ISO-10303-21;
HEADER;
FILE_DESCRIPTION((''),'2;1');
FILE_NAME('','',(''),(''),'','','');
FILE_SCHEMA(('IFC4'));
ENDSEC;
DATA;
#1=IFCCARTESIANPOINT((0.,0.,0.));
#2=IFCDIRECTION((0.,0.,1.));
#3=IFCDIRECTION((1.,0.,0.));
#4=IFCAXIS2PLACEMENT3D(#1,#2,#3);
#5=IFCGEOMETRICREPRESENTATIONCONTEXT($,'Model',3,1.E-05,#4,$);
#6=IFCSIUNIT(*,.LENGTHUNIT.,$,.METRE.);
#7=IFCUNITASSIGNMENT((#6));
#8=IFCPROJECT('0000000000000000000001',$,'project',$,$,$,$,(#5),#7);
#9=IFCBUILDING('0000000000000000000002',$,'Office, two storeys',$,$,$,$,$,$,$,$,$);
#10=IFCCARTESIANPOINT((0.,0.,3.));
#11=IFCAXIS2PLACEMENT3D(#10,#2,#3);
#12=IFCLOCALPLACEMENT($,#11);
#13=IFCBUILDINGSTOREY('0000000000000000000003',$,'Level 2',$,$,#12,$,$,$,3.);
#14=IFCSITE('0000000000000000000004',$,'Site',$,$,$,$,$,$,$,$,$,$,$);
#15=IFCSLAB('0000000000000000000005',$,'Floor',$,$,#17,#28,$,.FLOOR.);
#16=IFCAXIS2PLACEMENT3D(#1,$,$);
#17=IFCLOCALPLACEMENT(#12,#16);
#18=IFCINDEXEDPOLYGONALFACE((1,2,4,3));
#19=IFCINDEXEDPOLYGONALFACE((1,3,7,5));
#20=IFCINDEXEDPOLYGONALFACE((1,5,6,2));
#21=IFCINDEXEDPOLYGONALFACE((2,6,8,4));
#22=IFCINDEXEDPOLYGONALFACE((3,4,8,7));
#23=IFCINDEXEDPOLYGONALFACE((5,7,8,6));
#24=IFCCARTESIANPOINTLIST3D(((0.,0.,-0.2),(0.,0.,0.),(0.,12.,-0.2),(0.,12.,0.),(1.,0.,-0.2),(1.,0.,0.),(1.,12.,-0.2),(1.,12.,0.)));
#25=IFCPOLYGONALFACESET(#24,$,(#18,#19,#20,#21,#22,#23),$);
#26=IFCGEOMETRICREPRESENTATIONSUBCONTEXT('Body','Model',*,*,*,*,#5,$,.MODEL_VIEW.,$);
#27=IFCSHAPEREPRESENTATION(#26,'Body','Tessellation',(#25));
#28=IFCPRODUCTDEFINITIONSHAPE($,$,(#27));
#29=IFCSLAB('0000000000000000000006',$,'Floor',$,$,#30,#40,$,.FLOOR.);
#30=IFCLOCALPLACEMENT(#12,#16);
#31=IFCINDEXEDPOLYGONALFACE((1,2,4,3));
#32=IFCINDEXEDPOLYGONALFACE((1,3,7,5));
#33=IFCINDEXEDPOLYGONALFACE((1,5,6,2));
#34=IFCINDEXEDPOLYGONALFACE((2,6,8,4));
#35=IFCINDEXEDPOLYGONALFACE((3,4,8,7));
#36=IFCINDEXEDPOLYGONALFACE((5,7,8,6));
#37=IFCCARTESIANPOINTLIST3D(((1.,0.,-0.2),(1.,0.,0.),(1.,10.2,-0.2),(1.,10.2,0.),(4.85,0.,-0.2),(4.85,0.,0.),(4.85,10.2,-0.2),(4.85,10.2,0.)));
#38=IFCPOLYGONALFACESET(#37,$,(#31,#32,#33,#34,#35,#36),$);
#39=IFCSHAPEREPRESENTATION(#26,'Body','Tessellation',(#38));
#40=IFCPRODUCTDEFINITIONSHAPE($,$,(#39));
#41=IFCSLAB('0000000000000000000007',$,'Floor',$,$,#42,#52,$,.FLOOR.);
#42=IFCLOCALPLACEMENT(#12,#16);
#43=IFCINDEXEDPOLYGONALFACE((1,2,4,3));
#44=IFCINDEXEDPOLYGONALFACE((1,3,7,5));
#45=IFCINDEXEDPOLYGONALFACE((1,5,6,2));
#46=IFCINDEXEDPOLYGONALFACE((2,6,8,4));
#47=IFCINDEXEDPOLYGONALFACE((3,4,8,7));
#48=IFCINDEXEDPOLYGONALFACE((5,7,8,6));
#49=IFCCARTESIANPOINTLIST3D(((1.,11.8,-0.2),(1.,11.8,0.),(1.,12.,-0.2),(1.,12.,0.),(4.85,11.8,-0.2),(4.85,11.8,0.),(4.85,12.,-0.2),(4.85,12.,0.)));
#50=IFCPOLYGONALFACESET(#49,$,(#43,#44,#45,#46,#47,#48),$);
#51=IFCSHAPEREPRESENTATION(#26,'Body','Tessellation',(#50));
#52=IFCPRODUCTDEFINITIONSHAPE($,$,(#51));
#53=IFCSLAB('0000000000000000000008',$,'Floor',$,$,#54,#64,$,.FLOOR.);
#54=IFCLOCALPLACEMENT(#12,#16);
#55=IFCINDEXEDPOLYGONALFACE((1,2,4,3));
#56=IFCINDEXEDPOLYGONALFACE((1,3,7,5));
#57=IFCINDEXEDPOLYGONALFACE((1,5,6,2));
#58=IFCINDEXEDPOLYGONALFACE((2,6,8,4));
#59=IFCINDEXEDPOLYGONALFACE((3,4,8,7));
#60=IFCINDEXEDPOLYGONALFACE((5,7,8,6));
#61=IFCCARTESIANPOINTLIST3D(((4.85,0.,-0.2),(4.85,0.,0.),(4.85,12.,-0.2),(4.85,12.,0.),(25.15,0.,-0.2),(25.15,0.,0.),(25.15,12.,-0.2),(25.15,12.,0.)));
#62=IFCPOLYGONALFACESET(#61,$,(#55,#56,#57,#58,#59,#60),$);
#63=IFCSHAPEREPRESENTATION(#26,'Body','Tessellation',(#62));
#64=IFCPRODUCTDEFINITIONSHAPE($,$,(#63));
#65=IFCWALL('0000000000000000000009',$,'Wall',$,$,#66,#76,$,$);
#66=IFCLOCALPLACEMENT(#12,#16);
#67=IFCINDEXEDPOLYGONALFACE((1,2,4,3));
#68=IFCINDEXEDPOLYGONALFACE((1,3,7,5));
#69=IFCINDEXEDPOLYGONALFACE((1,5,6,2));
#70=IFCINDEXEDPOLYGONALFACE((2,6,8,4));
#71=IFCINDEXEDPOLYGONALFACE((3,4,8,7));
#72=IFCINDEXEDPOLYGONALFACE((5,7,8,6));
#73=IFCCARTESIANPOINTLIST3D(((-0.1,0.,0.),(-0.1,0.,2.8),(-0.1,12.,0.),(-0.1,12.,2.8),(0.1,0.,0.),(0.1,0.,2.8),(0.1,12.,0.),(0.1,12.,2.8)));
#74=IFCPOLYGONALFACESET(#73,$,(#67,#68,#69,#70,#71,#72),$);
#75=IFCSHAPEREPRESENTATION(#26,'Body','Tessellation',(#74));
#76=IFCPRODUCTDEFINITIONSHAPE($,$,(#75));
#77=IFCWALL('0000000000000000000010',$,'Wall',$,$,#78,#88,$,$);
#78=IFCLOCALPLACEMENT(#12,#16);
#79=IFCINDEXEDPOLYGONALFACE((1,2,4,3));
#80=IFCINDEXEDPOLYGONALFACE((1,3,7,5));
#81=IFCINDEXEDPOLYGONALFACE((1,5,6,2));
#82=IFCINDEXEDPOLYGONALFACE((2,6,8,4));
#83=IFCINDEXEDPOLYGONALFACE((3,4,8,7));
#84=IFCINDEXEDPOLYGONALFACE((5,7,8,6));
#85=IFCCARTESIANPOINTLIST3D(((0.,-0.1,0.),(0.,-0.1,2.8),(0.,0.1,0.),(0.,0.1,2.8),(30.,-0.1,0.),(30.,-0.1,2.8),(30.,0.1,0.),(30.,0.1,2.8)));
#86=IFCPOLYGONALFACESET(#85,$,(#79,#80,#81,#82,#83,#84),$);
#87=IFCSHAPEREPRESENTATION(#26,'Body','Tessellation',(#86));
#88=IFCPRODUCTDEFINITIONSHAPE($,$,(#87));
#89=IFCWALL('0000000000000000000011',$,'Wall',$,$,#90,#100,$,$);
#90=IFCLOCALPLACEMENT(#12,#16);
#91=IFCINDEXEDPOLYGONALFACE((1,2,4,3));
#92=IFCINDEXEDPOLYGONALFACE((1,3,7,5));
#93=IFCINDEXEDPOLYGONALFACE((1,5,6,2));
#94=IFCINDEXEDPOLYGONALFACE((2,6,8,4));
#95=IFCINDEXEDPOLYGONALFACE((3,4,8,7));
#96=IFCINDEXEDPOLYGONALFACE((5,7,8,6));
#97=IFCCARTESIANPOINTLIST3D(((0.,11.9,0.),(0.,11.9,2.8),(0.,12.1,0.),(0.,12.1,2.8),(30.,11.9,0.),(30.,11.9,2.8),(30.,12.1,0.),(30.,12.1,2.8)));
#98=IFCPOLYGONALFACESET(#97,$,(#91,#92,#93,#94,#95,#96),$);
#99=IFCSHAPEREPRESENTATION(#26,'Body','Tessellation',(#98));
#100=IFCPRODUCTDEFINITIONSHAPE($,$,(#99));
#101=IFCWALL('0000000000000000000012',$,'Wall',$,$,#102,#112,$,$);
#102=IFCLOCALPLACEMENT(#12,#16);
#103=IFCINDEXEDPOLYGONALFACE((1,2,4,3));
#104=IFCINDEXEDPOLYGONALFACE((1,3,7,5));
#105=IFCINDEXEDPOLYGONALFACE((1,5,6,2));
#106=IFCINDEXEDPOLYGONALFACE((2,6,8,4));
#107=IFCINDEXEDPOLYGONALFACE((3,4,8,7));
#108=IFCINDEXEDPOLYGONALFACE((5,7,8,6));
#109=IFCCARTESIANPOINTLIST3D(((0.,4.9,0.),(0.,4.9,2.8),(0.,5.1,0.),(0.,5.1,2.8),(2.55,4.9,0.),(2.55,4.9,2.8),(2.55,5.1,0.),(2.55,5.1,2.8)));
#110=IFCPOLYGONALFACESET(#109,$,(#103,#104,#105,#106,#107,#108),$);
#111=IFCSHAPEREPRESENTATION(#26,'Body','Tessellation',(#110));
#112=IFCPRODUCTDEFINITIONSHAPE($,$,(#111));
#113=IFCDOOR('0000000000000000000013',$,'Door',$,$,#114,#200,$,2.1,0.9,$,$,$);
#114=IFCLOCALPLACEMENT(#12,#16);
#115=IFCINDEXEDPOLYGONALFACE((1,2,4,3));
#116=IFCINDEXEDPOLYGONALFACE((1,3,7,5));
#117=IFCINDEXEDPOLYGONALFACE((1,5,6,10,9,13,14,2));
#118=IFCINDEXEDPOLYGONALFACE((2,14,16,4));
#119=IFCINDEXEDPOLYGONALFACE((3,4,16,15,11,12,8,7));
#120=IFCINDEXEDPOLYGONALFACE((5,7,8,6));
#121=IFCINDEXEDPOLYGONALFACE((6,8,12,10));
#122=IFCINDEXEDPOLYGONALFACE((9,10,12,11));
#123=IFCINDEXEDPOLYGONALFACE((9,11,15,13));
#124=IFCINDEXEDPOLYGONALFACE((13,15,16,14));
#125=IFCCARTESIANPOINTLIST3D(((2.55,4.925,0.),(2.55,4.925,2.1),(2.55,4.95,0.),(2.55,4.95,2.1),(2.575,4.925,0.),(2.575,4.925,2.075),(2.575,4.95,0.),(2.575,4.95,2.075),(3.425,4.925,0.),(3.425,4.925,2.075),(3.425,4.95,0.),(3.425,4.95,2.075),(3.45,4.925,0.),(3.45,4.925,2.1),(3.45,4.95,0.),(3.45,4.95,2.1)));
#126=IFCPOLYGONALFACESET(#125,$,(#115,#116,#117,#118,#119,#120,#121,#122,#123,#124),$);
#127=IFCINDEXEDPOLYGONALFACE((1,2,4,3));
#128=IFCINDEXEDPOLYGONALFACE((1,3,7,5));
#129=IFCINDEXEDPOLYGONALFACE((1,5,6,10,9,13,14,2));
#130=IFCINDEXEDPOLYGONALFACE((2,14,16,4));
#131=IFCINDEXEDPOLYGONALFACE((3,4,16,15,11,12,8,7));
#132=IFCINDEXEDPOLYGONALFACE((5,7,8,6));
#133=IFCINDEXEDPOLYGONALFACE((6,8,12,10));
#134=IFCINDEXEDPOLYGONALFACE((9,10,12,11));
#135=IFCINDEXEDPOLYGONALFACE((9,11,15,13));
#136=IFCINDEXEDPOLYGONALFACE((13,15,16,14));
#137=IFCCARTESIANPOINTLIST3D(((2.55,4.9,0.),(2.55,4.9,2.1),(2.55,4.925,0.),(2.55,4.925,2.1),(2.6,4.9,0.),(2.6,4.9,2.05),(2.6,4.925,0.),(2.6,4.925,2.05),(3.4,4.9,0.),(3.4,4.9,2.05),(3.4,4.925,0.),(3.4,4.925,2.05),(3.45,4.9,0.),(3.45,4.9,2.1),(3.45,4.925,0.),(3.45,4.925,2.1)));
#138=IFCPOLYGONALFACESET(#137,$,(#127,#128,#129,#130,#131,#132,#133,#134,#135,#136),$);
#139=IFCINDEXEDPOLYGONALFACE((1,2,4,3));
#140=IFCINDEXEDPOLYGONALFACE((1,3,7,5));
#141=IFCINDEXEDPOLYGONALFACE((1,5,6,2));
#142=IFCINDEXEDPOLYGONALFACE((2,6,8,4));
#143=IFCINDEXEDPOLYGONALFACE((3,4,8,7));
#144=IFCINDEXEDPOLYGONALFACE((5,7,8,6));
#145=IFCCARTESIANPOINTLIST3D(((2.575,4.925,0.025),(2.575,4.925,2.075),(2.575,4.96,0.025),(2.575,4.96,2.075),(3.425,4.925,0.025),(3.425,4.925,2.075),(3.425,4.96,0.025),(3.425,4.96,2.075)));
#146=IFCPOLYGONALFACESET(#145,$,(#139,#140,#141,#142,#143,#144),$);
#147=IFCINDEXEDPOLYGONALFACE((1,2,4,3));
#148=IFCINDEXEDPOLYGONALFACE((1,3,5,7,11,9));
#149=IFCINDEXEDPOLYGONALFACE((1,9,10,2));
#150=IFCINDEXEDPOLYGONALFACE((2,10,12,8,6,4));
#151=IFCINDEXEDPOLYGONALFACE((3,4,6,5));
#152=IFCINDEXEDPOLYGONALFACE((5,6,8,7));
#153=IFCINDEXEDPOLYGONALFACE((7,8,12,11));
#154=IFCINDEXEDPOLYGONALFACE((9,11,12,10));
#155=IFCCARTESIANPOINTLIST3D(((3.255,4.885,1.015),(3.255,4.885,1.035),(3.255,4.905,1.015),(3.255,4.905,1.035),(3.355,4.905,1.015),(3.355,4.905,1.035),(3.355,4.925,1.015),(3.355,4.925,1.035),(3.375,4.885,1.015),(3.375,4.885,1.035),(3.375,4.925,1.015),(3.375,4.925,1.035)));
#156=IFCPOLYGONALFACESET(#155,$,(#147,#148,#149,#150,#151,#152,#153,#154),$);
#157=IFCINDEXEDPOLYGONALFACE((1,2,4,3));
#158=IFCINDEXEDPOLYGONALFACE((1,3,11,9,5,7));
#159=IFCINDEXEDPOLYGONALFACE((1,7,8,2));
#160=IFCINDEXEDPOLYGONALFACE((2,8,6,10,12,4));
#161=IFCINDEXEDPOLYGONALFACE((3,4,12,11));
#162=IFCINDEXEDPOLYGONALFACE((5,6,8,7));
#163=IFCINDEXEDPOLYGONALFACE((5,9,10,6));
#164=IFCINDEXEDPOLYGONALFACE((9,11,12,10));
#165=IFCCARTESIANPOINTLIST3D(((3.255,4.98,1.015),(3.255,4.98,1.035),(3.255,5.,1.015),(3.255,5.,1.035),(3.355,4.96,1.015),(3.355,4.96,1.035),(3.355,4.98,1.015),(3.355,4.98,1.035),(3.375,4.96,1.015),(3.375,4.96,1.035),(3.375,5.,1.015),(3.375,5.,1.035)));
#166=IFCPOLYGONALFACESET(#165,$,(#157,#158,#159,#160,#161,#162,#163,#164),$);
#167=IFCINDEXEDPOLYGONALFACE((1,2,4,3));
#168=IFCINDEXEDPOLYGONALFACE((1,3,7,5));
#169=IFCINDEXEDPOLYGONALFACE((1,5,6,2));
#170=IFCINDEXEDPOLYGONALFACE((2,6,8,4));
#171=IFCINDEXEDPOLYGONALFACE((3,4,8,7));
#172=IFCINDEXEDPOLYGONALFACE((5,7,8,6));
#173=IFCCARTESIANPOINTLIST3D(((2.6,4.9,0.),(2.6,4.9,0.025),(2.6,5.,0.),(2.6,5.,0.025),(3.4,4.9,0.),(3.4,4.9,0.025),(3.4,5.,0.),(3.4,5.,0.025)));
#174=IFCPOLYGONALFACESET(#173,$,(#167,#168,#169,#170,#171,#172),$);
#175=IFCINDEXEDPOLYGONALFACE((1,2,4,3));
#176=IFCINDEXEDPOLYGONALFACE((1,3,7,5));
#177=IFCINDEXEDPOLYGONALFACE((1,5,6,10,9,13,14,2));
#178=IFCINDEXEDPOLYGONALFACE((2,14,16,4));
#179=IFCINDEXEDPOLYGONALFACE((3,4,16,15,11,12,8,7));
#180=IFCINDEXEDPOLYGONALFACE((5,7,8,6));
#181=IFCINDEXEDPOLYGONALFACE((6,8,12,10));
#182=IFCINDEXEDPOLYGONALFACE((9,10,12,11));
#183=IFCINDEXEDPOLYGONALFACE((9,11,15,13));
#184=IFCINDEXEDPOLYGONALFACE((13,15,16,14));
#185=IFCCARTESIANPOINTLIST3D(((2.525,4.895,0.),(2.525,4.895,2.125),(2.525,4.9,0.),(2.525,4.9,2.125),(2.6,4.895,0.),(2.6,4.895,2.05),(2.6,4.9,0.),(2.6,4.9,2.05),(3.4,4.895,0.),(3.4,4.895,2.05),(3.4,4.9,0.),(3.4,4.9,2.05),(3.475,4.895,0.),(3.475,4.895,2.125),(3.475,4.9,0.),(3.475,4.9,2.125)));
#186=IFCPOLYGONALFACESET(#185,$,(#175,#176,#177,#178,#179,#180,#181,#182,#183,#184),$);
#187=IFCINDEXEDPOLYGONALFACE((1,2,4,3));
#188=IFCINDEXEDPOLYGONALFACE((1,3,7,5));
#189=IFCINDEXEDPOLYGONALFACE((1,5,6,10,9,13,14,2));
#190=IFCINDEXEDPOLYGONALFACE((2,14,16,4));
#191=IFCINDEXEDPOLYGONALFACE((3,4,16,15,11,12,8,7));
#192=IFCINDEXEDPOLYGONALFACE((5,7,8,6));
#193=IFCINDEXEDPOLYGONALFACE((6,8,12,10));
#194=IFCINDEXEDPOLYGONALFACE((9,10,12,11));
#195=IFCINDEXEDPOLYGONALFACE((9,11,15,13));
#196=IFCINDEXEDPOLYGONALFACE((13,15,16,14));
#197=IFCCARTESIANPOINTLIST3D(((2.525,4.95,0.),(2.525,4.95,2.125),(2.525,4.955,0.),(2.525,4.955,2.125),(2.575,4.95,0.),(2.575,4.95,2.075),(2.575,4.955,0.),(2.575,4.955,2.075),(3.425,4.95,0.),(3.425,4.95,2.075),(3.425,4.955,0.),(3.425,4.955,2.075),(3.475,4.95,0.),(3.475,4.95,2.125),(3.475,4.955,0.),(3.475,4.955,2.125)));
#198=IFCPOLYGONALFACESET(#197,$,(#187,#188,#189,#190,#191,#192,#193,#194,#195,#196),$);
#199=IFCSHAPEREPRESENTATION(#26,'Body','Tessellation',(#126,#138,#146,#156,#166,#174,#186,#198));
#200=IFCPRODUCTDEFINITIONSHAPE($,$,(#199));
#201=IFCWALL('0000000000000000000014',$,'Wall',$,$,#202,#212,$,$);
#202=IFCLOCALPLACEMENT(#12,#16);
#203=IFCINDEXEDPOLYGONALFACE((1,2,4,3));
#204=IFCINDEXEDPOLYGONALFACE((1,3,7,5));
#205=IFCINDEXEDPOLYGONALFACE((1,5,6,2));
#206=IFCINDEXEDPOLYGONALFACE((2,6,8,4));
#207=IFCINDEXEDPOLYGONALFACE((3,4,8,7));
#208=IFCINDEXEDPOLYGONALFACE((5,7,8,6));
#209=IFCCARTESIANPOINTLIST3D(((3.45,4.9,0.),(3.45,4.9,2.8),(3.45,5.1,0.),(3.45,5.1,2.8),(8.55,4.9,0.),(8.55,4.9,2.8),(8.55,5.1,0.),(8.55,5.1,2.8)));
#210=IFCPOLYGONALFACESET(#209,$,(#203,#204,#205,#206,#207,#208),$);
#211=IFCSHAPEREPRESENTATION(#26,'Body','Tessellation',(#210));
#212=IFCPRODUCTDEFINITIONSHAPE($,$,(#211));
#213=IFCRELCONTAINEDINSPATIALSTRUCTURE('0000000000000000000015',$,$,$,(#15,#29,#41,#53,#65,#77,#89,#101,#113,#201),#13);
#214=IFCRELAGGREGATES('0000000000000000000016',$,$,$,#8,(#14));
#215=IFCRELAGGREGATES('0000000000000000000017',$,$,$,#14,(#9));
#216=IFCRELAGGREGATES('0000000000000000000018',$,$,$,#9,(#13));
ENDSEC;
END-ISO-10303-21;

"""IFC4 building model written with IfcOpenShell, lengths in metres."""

from ifc_helpers import new_model, si_unit, frame, origin_with_axes, place, context, subcontext, project, spatial, line, indexed_curve, outline, extrude, element, save


model = new_model("IFC4")

# Units and contexts
model_context = context("Model", 3, precision=1e-05, world=origin_with_axes())
body_context = subcontext(model_context, "Body", "Model", "MODEL_VIEW")
ifc_project = project(units=[si_unit("LENGTHUNIT", "METRE")], contexts=[model_context])

# Site, building, storey
site = spatial("IfcSite", under=ifc_project, Name="Site")
building = spatial("IfcBuilding", under=site, Name="Office, two storeys")
storey_placement = place(None, frame((0.0, 0.0, 3.0), z_axis=(0.0, 0.0, 1.0), x_axis=(1.0, 0.0, 0.0)))
storey = spatial("IfcBuildingStorey", under=building, at=storey_placement, Name="Level 2", Elevation=3.0)

# Slabs
slab_1_placement = place(storey_placement, frame((0.0, 0.0, -0.2), z_axis=(0.0, 0.0, 1.0), x_axis=(1.0, 0.0, 0.0)))
element("IfcSlab", 1, at=slab_1_placement, inside=storey, Name="Floor", PredefinedType="FLOOR", context=body_context, shape_type="SweptSolid", body=[
    extrude(outline(indexed_curve([(0.0, 0.0), (1.0, 0.0), (1.0, 12.0), (0.0, 12.0)])), None, (0.0, 0.0, 1.0), 0.2),
])
slab_2_placement = place(storey_placement, frame((1.0, 0.0, -0.2), z_axis=(0.0, 0.0, 1.0), x_axis=(1.0, 0.0, 0.0)))
element("IfcSlab", 2, at=slab_2_placement, inside=storey, Name="Floor", PredefinedType="FLOOR", context=body_context, shape_type="SweptSolid", body=[
    extrude(outline(indexed_curve([(0.0, 0.0), (3.85, 0.0), (3.85, 10.2), (0.0, 10.2)])), None, (0.0, 0.0, 1.0), 0.2),
])
slab_3_placement = place(storey_placement, frame((1.0, 11.8, -0.2), z_axis=(0.0, 0.0, 1.0), x_axis=(1.0, 0.0, 0.0)))
element("IfcSlab", 3, at=slab_3_placement, inside=storey, Name="Floor", PredefinedType="FLOOR", context=body_context, shape_type="SweptSolid", body=[
    extrude(outline(indexed_curve([(0.0, 0.0), (3.85, 0.0), (3.85, 0.2), (0.0, 0.2)])), None, (0.0, 0.0, 1.0), 0.2),
])
slab_4_placement = place(storey_placement, frame((4.85, 0.0, -0.2), z_axis=(0.0, 0.0, 1.0), x_axis=(1.0, 0.0, 0.0)))
element("IfcSlab", 4, at=slab_4_placement, inside=storey, Name="Floor", PredefinedType="FLOOR", context=body_context, shape_type="SweptSolid", body=[
    extrude(outline(indexed_curve([(0.0, 0.0), (20.3, 0.0), (20.3, 12.0), (0.0, 12.0)])), None, (0.0, 0.0, 1.0), 0.2),
])

# Walls
wall_1_placement = place(storey_placement, frame((0.0, 0.0, 0.0), z_axis=(0.0, 0.0, 1.0), x_axis=(0.0, 1.0, 0.0)))
element("IfcWall", 5, at=wall_1_placement, inside=storey, Name="Wall", context=body_context, shape_type="SweptSolid", body=[
    extrude(outline(indexed_curve([(0.0, 0.0), (0.0, 0.2), (12.0, 0.2), (12.0, 0.0), (0.0, 0.0)], self_intersect=False)), frame((0.0, -0.1, 0.0), z_axis=(0.0, 0.0, 1.0), x_axis=(1.0, 0.0, 0.0)), (0.0, 0.0, 1.0), 2.8),
])
for number, where, z_axis, x_axis, name in (
    (6, (0.0, 0.0, 0.0), (0.0, 0.0, 1.0), (1.0, 0.0, 0.0), "Wall"),
    (7, (0.0, 12.0, 0.0), (0.0, 0.0, 1.0), (1.0, 0.0, 0.0), "Wall"),
):
    element("IfcWall", number, at=place(storey_placement, frame(where, z_axis=z_axis, x_axis=x_axis)), inside=storey, Name=name, context=body_context, shape_type="SweptSolid", body=[
        extrude(outline(indexed_curve([(0.0, 0.0), (0.0, 0.2), (30.0, 0.2), (30.0, 0.0), (0.0, 0.0)], self_intersect=False)), frame((0.0, -0.1, 0.0), z_axis=(0.0, 0.0, 1.0), x_axis=(1.0, 0.0, 0.0)), (0.0, 0.0, 1.0), 2.8),
    ])
wall_2_placement = place(storey_placement, frame((0.0, 5.0, 0.0), z_axis=(0.0, 0.0, 1.0), x_axis=(1.0, 0.0, 0.0)))
element("IfcWall", 8, at=wall_2_placement, inside=storey, Name="Wall", context=body_context, shape_type="SweptSolid", body=[
    extrude(outline(indexed_curve([(0.0, 0.0), (0.0, 0.2), (2.55, 0.2), (2.55, 0.0), (0.0, 0.0)], self_intersect=False)), frame((0.0, -0.1, 0.0), z_axis=(0.0, 0.0, 1.0), x_axis=(1.0, 0.0, 0.0)), (0.0, 0.0, 1.0), 2.8),
])

# Door
door_1_placement = place(storey_placement, frame((2.55, 4.9, 0.0), z_axis=(0.0, 0.0, 1.0), x_axis=(1.0, 0.0, 0.0)))
element("IfcDoor", 9, at=door_1_placement, inside=storey, Name="Door", OverallHeight=2.1, OverallWidth=0.9, context=body_context, shape_type="SweptSolid", body=[
    extrude(outline(indexed_curve([(0.0, 0.0), (0.0, 2.1), (0.9, 2.1), (0.9, 0.0), (0.875, 0.0), (0.875, 2.075), (0.025, 2.075), (0.025, 0.0)], segments=[line(1, 2, 3, 4, 5, 6, 7, 8, 1)])), frame((0.0, 0.025, 0.0), z_axis=(0.0, -1.0, 0.0), x_axis=(1.0, 0.0, 0.0)), (0.0, 0.0, -1.0), 0.025),
    extrude(outline(indexed_curve([(0.0, 0.0), (0.0, 2.1), (0.9, 2.1), (0.9, 0.0), (0.85, 0.0), (0.85, 2.05), (0.05, 2.05), (0.05, 0.0)], segments=[line(1, 2, 3, 4, 5, 6, 7, 8, 1)])), frame((0.0, 0.0, 0.0), z_axis=(0.0, -1.0, 0.0), x_axis=(1.0, 0.0, 0.0)), (0.0, 0.0, -1.0), 0.025),
    extrude(outline(indexed_curve([(0.0, 0.0), (0.85, 0.0), (0.85, 0.035), (0.0, 0.035)], segments=[line(1, 2, 3, 4, 1)])), frame((0.025, 0.025, 0.025), z_axis=(0.0, 0.0, 1.0), x_axis=(1.0, 0.0, 0.0)), (0.0, 0.0, 1.0), 2.05),
    extrude(outline(indexed_curve([(0.0, 0.0), (0.0, -0.04), (-0.12, -0.04), (-0.12, -0.02), (-0.02, -0.02), (-0.02, 0.0)], segments=[line(1, 2, 3, 4, 5, 6, 1)])), frame((0.825, 0.025, 1.015), z_axis=(0.0, 0.0, 1.0), x_axis=(1.0, 0.0, 0.0)), (0.0, 0.0, 1.0), 0.02),
    extrude(outline(indexed_curve([(0.0, 0.0), (0.0, 0.04), (-0.12, 0.04), (-0.12, 0.02), (-0.02, 0.02), (-0.02, 0.0)], segments=[line(1, 2, 3, 4, 5, 6, 1)])), frame((0.825, 0.06, 1.015), z_axis=(0.0, 0.0, 1.0), x_axis=(1.0, 0.0, 0.0)), (0.0, 0.0, 1.0), 0.02),
    extrude(outline(indexed_curve([(0.0, 0.0), (0.8, 0.0), (0.8, 0.1), (0.0, 0.1)], segments=[line(1, 2, 3, 4, 1)])), frame((0.05, 0.0, 0.0), z_axis=(0.0, 0.0, 1.0), x_axis=(1.0, 0.0, 0.0)), (0.0, 0.0, 1.0), 0.025),
    extrude(outline(indexed_curve([(0.0, 0.0), (0.0, 2.125), (0.95, 2.125), (0.95, 0.0), (0.875, 0.0), (0.875, 2.05), (0.075, 2.05), (0.075, 0.0)], segments=[line(1, 2, 3, 4, 5, 6, 7, 8, 1)])), frame((-0.025, -0.005, 0.0), z_axis=(0.0, -1.0, 0.0), x_axis=(1.0, 0.0, 0.0)), (0.0, 0.0, -1.0), 0.005),
    extrude(outline(indexed_curve([(0.0, 0.0), (0.0, 2.125), (0.95, 2.125), (0.95, 0.0), (0.9, 0.0), (0.9, 2.075), (0.05, 2.075), (0.05, 0.0)], segments=[line(1, 2, 3, 4, 5, 6, 7, 8, 1)])), frame((-0.025, 0.05, 0.0), z_axis=(0.0, -1.0, 0.0), x_axis=(1.0, 0.0, 0.0)), (0.0, 0.0, -1.0), 0.005),
])

# Wall
wall_3_placement = place(storey_placement, frame((3.45, 5.0, 0.0), z_axis=(0.0, 0.0, 1.0), x_axis=(1.0, 0.0, 0.0)))
element("IfcWall", 10, at=wall_3_placement, inside=storey, Name="Wall", context=body_context, shape_type="SweptSolid", body=[
    extrude(outline(indexed_curve([(0.0, 0.0), (0.0, 0.2), (5.1, 0.2), (5.1, 0.0), (0.0, 0.0)], self_intersect=False)), frame((0.0, -0.1, 0.0), z_axis=(0.0, 0.0, 1.0), x_axis=(1.0, 0.0, 0.0)), (0.0, 0.0, 1.0), 2.8),
])

save(model, "model.ifc")
